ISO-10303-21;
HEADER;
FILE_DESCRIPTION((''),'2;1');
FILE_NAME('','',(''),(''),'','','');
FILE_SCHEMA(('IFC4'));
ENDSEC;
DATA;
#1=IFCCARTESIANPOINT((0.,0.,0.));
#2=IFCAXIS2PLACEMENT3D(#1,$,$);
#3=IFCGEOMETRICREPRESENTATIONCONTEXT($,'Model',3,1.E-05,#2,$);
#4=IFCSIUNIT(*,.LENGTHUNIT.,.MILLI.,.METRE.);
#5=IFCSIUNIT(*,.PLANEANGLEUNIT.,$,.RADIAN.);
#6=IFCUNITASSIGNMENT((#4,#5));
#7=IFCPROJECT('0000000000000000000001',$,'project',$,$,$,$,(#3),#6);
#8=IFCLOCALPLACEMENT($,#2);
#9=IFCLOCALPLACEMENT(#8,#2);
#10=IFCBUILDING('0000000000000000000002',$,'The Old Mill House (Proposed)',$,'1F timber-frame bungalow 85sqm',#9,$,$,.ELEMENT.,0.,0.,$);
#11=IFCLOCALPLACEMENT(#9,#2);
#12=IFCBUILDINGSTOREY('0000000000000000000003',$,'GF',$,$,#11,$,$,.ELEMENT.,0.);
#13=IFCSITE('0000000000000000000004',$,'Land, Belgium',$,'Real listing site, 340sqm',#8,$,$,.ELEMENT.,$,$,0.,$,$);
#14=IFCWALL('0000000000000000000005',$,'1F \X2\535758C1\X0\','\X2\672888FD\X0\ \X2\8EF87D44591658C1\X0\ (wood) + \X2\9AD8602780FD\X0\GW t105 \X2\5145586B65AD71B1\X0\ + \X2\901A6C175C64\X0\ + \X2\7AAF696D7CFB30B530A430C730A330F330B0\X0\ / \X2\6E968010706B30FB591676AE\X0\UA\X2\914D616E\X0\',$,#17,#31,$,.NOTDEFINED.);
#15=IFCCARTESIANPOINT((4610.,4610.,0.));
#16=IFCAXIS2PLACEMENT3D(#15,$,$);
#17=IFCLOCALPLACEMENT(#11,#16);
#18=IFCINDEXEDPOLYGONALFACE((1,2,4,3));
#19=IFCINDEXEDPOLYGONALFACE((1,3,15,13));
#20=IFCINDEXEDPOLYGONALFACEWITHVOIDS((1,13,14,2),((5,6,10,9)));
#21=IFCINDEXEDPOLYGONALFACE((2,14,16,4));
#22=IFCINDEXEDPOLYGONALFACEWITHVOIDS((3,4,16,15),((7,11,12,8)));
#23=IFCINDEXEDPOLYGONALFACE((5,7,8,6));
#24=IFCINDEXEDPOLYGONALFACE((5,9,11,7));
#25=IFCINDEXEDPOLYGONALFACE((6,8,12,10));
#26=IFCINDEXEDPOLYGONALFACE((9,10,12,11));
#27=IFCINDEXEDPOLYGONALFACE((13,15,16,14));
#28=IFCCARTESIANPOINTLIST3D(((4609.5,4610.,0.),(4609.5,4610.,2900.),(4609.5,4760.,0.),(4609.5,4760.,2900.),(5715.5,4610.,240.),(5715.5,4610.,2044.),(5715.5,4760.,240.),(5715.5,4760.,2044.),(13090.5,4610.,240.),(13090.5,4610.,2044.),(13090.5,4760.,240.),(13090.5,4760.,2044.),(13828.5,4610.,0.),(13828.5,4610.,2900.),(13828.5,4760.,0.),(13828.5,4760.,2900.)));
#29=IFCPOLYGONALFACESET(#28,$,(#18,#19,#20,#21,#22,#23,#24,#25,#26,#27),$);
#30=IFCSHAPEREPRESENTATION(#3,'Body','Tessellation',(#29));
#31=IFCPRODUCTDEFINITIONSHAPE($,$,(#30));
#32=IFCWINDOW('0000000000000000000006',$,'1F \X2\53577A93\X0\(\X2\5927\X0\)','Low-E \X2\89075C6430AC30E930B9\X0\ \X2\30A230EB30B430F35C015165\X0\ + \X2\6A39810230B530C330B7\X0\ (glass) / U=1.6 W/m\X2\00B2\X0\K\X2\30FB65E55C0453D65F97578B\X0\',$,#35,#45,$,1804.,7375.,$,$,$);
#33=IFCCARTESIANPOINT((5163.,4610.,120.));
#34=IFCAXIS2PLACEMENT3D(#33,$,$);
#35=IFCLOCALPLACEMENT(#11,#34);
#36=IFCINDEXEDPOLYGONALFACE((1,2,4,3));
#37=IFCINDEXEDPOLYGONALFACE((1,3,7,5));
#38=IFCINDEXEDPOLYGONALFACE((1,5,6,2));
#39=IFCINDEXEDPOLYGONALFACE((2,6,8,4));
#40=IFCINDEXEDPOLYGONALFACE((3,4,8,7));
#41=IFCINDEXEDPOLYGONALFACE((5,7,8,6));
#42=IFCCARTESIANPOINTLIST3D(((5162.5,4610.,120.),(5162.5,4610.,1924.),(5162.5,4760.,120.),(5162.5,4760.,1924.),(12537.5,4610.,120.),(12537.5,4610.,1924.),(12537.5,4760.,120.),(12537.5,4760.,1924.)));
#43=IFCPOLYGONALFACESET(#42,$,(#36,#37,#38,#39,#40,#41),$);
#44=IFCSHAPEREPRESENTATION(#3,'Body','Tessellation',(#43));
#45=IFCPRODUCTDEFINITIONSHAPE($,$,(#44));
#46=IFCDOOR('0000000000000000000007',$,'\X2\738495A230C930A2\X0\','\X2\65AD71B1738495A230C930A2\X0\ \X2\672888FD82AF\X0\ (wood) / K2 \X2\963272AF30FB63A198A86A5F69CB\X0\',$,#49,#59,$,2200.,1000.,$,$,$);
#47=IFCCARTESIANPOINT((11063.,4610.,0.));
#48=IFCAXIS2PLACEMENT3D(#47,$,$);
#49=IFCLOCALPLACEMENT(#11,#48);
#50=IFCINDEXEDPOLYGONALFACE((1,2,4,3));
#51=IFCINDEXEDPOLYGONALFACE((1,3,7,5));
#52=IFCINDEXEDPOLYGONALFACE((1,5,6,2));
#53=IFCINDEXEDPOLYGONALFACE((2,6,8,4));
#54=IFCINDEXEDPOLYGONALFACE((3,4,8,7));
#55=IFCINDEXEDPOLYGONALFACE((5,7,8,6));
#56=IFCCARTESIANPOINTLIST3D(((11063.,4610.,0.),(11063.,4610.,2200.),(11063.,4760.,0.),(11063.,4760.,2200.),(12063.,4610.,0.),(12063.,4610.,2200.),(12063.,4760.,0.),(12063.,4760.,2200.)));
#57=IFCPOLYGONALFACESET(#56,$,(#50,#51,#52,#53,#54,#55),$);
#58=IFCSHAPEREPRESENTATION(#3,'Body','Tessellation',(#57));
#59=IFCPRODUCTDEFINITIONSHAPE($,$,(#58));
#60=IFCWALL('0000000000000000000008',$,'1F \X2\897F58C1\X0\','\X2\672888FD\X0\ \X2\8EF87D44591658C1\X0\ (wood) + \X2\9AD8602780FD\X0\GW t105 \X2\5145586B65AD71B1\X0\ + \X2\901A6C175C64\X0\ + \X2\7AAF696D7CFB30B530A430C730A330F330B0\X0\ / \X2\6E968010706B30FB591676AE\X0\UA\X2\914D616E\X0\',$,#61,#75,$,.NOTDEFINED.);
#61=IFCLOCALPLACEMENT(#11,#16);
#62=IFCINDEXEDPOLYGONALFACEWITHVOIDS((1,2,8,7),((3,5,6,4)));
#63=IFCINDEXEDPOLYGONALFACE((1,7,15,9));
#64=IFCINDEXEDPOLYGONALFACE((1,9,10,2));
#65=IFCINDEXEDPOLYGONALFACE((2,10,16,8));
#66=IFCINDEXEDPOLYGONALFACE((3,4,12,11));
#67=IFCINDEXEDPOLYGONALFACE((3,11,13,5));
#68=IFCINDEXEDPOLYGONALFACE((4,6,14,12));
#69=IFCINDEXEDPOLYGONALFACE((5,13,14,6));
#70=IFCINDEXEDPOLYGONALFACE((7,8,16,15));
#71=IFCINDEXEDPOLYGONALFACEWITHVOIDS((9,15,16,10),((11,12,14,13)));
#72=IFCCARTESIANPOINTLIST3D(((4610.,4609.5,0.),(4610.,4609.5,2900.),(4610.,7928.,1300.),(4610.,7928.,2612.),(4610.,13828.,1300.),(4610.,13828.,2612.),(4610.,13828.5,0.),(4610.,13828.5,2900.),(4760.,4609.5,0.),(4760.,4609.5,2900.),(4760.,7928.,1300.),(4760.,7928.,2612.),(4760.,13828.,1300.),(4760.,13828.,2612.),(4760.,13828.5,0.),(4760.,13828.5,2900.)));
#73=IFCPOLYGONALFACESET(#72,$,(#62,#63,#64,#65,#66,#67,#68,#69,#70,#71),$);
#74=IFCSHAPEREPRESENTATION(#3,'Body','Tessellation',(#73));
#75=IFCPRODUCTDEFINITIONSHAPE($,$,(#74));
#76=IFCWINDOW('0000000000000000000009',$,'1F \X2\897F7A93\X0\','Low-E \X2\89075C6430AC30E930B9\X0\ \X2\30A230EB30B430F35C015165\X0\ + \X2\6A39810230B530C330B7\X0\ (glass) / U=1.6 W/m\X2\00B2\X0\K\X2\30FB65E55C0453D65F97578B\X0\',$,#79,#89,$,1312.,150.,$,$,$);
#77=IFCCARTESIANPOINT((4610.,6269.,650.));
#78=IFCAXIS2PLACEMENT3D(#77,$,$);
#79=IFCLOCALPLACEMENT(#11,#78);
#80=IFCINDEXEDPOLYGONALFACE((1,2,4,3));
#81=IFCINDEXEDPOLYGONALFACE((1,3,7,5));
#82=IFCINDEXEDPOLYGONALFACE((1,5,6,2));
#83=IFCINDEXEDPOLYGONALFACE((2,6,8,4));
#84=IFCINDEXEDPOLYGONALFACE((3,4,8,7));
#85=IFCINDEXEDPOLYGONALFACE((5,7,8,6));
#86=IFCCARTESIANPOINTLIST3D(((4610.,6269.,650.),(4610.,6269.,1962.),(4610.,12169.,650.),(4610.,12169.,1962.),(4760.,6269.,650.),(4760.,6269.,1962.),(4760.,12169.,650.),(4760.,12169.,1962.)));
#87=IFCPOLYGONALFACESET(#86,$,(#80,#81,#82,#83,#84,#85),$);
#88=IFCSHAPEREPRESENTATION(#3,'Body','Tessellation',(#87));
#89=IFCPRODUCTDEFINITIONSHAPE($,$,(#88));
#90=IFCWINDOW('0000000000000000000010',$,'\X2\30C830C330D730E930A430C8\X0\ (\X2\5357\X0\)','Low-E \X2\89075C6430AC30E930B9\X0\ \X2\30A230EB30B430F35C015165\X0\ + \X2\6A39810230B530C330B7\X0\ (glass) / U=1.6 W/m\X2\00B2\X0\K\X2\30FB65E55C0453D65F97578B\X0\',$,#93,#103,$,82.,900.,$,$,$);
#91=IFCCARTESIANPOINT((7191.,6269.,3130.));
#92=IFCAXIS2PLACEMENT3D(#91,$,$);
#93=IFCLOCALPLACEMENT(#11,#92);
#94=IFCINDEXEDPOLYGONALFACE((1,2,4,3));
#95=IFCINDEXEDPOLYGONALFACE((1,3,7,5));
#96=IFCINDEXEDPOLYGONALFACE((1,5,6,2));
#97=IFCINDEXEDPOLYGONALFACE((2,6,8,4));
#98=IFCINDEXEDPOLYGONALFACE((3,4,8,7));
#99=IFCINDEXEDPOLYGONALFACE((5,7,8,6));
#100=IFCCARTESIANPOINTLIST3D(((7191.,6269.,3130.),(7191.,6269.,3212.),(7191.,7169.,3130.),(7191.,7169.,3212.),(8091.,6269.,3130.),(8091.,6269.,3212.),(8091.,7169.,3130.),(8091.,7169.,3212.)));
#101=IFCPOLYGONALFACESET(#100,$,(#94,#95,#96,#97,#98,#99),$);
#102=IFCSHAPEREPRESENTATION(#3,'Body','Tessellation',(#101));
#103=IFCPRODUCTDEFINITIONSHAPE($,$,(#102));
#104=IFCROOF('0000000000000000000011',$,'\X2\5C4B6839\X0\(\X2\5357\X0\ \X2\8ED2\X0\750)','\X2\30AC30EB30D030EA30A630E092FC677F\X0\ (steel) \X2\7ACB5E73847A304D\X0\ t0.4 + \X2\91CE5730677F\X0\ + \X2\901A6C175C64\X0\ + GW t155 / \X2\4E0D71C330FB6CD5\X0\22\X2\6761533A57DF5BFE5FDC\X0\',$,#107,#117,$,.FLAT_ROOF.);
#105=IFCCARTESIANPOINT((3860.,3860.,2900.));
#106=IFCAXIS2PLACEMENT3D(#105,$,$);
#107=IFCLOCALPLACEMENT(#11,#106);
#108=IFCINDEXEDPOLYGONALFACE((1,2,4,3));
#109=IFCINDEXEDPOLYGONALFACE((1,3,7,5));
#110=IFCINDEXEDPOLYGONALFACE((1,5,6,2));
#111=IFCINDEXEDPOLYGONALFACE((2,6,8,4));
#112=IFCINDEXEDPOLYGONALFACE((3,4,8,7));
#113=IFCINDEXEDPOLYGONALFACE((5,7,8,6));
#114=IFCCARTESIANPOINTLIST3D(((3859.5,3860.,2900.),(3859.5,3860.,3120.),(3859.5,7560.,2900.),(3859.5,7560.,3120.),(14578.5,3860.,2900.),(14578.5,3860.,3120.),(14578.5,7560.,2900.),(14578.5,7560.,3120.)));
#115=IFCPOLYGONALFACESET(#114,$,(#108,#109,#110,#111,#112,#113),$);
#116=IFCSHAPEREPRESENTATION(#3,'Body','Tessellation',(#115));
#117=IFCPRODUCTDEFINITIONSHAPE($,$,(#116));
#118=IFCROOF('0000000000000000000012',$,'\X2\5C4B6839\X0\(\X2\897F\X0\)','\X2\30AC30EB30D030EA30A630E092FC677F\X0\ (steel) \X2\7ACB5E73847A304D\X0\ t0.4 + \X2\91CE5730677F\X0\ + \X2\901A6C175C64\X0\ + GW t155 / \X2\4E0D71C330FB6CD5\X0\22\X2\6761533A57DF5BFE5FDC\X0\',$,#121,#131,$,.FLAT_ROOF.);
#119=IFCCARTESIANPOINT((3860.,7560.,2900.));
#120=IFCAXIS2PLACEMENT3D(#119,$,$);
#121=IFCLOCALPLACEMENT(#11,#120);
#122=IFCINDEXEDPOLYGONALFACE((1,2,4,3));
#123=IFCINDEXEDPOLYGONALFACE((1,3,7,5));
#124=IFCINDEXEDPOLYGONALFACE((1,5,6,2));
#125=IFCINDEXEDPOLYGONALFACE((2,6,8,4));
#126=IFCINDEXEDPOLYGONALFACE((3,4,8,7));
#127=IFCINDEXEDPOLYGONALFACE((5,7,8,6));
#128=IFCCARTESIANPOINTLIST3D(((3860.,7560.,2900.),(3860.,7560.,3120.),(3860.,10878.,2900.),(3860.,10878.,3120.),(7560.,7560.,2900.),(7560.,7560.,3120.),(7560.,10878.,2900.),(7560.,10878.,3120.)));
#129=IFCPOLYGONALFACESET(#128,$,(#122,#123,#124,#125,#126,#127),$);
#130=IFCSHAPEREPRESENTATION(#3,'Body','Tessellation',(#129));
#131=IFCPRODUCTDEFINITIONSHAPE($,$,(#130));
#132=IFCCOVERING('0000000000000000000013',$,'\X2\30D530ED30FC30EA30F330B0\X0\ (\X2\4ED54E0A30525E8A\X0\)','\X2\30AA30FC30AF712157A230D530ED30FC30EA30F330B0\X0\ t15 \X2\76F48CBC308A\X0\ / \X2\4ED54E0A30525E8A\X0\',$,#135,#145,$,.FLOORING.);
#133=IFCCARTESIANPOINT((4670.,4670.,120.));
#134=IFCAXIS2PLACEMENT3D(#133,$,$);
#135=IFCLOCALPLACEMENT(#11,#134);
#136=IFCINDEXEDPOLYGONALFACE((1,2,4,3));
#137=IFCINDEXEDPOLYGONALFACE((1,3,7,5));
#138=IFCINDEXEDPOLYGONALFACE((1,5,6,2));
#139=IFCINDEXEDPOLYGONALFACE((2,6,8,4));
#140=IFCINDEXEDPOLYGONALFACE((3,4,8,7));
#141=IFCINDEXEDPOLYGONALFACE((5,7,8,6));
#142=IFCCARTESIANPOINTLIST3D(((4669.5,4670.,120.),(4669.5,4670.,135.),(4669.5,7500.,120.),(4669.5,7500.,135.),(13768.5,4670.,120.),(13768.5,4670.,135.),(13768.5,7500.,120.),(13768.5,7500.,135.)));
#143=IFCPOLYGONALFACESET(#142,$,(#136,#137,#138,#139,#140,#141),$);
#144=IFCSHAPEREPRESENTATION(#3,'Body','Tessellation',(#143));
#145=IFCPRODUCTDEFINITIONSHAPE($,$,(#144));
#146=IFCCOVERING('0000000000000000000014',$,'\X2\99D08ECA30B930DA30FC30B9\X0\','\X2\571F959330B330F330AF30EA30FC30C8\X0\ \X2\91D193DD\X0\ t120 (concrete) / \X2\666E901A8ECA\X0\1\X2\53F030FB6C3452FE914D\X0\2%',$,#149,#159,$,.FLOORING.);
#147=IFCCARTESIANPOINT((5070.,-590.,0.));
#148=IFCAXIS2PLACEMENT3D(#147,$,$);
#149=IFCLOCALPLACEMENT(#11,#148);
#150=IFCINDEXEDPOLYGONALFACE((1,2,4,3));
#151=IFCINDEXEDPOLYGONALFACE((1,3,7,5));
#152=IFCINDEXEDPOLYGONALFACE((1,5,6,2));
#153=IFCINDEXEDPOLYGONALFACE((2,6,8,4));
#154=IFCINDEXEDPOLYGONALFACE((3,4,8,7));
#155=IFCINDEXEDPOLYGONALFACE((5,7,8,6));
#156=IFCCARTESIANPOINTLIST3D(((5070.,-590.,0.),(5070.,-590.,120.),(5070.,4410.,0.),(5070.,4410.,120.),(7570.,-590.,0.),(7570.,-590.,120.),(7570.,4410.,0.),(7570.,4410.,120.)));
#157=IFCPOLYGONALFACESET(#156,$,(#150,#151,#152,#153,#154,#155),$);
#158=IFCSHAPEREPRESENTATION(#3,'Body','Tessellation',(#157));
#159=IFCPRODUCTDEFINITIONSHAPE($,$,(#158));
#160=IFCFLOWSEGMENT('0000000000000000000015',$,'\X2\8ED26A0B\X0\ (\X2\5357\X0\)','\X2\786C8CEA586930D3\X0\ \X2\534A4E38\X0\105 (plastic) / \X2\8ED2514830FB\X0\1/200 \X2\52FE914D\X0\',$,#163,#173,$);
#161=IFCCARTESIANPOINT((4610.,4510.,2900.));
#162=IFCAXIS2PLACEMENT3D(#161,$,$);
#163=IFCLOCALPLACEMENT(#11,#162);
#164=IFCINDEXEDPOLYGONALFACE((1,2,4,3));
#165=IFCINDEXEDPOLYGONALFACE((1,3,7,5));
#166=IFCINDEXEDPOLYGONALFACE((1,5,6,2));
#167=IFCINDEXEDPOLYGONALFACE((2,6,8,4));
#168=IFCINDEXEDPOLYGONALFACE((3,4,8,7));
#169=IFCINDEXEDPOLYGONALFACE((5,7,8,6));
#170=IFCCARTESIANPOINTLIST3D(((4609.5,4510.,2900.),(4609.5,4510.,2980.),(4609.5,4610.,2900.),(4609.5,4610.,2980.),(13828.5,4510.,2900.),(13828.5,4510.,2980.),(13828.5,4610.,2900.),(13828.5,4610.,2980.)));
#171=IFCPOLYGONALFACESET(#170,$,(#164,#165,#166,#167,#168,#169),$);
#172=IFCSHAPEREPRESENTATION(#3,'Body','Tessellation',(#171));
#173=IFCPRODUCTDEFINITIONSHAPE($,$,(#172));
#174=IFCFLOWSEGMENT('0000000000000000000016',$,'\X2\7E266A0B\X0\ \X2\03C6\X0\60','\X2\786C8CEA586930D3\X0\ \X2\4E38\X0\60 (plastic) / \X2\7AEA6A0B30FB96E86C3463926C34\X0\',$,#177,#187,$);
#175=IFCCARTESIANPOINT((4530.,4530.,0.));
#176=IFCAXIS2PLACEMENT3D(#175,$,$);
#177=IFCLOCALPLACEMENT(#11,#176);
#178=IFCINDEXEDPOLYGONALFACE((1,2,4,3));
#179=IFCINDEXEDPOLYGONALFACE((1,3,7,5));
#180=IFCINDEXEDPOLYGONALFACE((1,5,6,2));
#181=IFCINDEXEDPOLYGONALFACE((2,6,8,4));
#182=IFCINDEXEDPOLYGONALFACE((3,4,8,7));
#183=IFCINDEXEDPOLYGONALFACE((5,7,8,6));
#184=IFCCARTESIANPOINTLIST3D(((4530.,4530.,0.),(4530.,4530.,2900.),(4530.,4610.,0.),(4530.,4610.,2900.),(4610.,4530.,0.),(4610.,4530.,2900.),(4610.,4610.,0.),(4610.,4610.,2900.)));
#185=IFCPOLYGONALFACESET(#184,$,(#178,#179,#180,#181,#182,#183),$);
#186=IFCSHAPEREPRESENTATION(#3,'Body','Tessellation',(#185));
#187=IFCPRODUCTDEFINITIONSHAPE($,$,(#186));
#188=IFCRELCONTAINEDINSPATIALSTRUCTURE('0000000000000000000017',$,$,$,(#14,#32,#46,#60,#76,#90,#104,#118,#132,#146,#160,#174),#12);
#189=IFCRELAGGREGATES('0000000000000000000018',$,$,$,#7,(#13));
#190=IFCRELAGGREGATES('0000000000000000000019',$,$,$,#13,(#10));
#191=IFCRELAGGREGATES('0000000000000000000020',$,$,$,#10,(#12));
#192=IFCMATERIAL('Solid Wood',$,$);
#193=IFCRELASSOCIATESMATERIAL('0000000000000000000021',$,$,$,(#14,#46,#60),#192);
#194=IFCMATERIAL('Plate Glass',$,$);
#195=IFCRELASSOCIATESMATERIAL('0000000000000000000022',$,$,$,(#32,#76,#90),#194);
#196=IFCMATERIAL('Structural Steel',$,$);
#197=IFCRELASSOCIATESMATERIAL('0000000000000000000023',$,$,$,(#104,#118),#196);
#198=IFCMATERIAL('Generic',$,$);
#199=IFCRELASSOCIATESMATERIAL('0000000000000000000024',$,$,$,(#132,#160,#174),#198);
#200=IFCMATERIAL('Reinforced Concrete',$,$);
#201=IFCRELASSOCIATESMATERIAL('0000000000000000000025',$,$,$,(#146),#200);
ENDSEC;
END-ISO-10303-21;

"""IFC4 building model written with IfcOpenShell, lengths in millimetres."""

from ifc_helpers import new_model, si_unit, frame, frame_2d, origin, place, context, project, spatial, rectangle, extrude, material, element, fill, save


model = new_model("IFC4")

# Units and contexts
model_context = context("Model", 3, precision=1e-05, world=origin())
ifc_project = project(units=[si_unit("LENGTHUNIT", "METRE", prefix="MILLI"), si_unit("PLANEANGLEUNIT", "RADIAN")], contexts=[model_context])

# Site, building, storey
site_placement = place(None, origin())
site = spatial("IfcSite", under=ifc_project, at=site_placement, Name="Land, Belgium", ObjectType="Real listing site, 340sqm", CompositionType="ELEMENT", RefElevation=0.0)
building_placement = place(site_placement, origin())
building = spatial("IfcBuilding", under=site, at=building_placement, Name="The Old Mill House (Proposed)", ObjectType="1F timber-frame bungalow 85sqm", CompositionType="ELEMENT", ElevationOfRefHeight=0.0, ElevationOfTerrain=0.0)
storey_placement = place(building_placement, origin())
storey = spatial("IfcBuildingStorey", under=building, at=storey_placement, Name="GF", CompositionType="ELEMENT", Elevation=0.0)

# Shared definitions
ifc_material_1 = material(Name="Solid Wood")

# Shared definitions
ifc_material_2 = material(Name="Reinforced Concrete")

# Wall, openings, window, door
wall_1_placement = place(storey_placement, frame((4610.0, 4610.0, 0.0)))
wall_1 = element("IfcWall", 1, at=wall_1_placement, inside=storey, material=ifc_material_1, Name="1F 南壁", Description="木製 軸組外壁 (wood) + 高性能GW t105 充填断熱 + 通気層 + 窯業系サイディング / 準耐火・外皮UA配慮", PredefinedType="NOTDEFINED", context=model_context, shape_type="SweptSolid", body=[
    extrude(rectangle(XDim=9219.0, YDim=150.0, at=frame_2d((4609.0, 75.0))), frame((4610.0, 4610.0, 0.0)), (0.0, 0.0, 1.0), 2900.0),
])
opening_1_placement = place(storey_placement, frame((5163.0, 4610.0, 120.0)))
opening_1 = element("IfcOpeningElement", 2, at=opening_1_placement, cuts=wall_1, PredefinedType="NOTDEFINED", context=model_context, shape_type="SweptSolid", body=[
    extrude(rectangle(XDim=7375.0, YDim=150.0, at=frame_2d((3687.0, 75.0))), frame((5163.0, 4610.0, 120.0)), (0.0, 0.0, 1.0), 1804.0),
])
opening_2_placement = place(storey_placement, frame((11063.0, 4610.0, 0.0)))
opening_2 = element("IfcOpeningElement", 3, at=opening_2_placement, cuts=wall_1, PredefinedType="NOTDEFINED", context=model_context, shape_type="SweptSolid", body=[
    extrude(rectangle(XDim=1000.0, YDim=150.0, at=frame_2d((500.0, 75.0))), frame((11063.0, 4610.0, 0.0)), (0.0, 0.0, 1.0), 2200.0),
])
ifc_material_3 = material(Name="Plate Glass")
window_1_placement = place(storey_placement, frame((5163.0, 4610.0, 120.0)))
window_1 = element("IfcWindow", 4, at=window_1_placement, inside=storey, material=ifc_material_3, Name="1F 南窓(大)", Description="Low-E 複層ガラス アルゴン封入 + 樹脂サッシ (glass) / U=1.6 W/m²K・日射取得型", OverallHeight=1804.0, OverallWidth=7375.0, context=model_context, shape_type="SweptSolid", body=[
    extrude(rectangle(XDim=7375.0, YDim=150.0, at=frame_2d((3687.0, 75.0))), frame((5163.0, 4610.0, 120.0)), (0.0, 0.0, 1.0), 1804.0),
])
fill(opening_1, window_1)
door_placement = place(storey_placement, frame((11063.0, 4610.0, 0.0)))
door = element("IfcDoor", 5, at=door_placement, inside=storey, material=ifc_material_1, Name="玄関ドア", Description="断熱玄関ドア 木製芯 (wood) / K2 防犯・採風機構", OverallHeight=2200.0, OverallWidth=1000.0, context=model_context, shape_type="SweptSolid", body=[
    extrude(rectangle(XDim=1000.0, YDim=150.0, at=frame_2d((500.0, 75.0))), frame((11063.0, 4610.0, 0.0)), (0.0, 0.0, 1.0), 2200.0),
])
fill(opening_2, door)

# Wall, opening, window
wall_2_placement = place(storey_placement, frame((4610.0, 4610.0, 0.0)))
wall_2 = element("IfcWall", 6, at=wall_2_placement, inside=storey, material=ifc_material_1, Name="1F 西壁", Description="木製 軸組外壁 (wood) + 高性能GW t105 充填断熱 + 通気層 + 窯業系サイディング / 準耐火・外皮UA配慮", PredefinedType="NOTDEFINED", context=model_context, shape_type="SweptSolid", body=[
    extrude(rectangle(XDim=150.0, YDim=9219.0, at=frame_2d((75.0, 4609.0))), frame((4610.0, 4610.0, 0.0)), (0.0, 0.0, 1.0), 2900.0),
])
opening_3_placement = place(storey_placement, frame((4610.0, 6269.0, 650.0)))
opening_3 = element("IfcOpeningElement", 7, at=opening_3_placement, cuts=wall_2, PredefinedType="NOTDEFINED", context=model_context, shape_type="SweptSolid", body=[
    extrude(rectangle(XDim=150.0, YDim=5900.0, at=frame_2d((75.0, 2950.0))), frame((4610.0, 6269.0, 650.0)), (0.0, 0.0, 1.0), 1312.0),
])
window_2_placement = place(storey_placement, frame((4610.0, 6269.0, 650.0)))
window_2 = element("IfcWindow", 8, at=window_2_placement, inside=storey, material=ifc_material_3, Name="1F 西窓", Description="Low-E 複層ガラス アルゴン封入 + 樹脂サッシ (glass) / U=1.6 W/m²K・日射取得型", OverallHeight=1312.0, OverallWidth=150.0, context=model_context, shape_type="SweptSolid", body=[
    extrude(rectangle(XDim=150.0, YDim=5900.0, at=frame_2d((75.0, 2950.0))), frame((4610.0, 6269.0, 650.0)), (0.0, 0.0, 1.0), 1312.0),
])
fill(opening_3, window_2)

# Window
window_3_placement = place(storey_placement, frame((7191.0, 6269.0, 3130.0)))
element("IfcWindow", 9, at=window_3_placement, inside=storey, material=ifc_material_3, Name="トップライト (南)", Description="Low-E 複層ガラス アルゴン封入 + 樹脂サッシ (glass) / U=1.6 W/m²K・日射取得型", OverallHeight=82.0, OverallWidth=900.0, context=model_context, shape_type="SweptSolid", body=[
    extrude(rectangle(XDim=900.0, YDim=900.0, at=frame_2d((450.0, 450.0))), frame((7191.0, 6269.0, 3130.0)), (0.0, 0.0, 1.0), 82.0),
])

# Roofs
ifc_material_4 = material(Name="Structural Steel")
roof_1_placement = place(storey_placement, frame((3860.0, 3860.0, 2900.0)))
element("IfcRoof", 10, at=roof_1_placement, inside=storey, material=ifc_material_4, Name="屋根(南 軒750)", Description="ガルバリウム鋼板 (steel) 立平葺き t0.4 + 野地板 + 通気層 + GW t155 / 不燃・法22条区域対応", PredefinedType="FLAT_ROOF", context=model_context, shape_type="SweptSolid", body=[
    extrude(rectangle(XDim=10719.0, YDim=3700.0, at=frame_2d((5359.0, 1850.0))), frame((3860.0, 3860.0, 2900.0)), (0.0, 0.0, 1.0), 220.0),
])
roof_2_placement = place(storey_placement, frame((3860.0, 7560.0, 2900.0)))
element("IfcRoof", 11, at=roof_2_placement, inside=storey, material=ifc_material_4, Name="屋根(西)", Description="ガルバリウム鋼板 (steel) 立平葺き t0.4 + 野地板 + 通気層 + GW t155 / 不燃・法22条区域対応", PredefinedType="FLAT_ROOF", context=model_context, shape_type="SweptSolid", body=[
    extrude(rectangle(XDim=3700.0, YDim=3318.0, at=frame_2d((1850.0, 1659.0))), frame((3860.0, 7560.0, 2900.0)), (0.0, 0.0, 1.0), 220.0),
])

# Coverings
ifc_material_5 = material(Name="Generic")
covering_1_placement = place(storey_placement, frame((4670.0, 4670.0, 120.0)))
element("IfcCovering", 12, at=covering_1_placement, inside=storey, material=ifc_material_5, Name="フローリング (仕上げ床)", Description="オーク無垢フローリング t15 直貼り / 仕上げ床", PredefinedType="FLOORING", context=model_context, shape_type="SweptSolid", body=[
    extrude(rectangle(XDim=9099.0, YDim=2830.0, at=frame_2d((4549.0, 1415.0))), frame((4670.0, 4670.0, 120.0)), (0.0, 0.0, 1.0), 15.0),
])
covering_2_placement = place(storey_placement, frame((5070.0, -590.0, 0.0)))
element("IfcCovering", 13, at=covering_2_placement, inside=storey, material=ifc_material_2, Name="駐車スペース", Description="土間コンクリート 金鏝 t120 (concrete) / 普通車1台・水勾配2%", PredefinedType="FLOORING", context=model_context, shape_type="SweptSolid", body=[
    extrude(rectangle(XDim=2500.0, YDim=5000.0, at=frame_2d((1250.0, 2500.0))), frame((5070.0, -590.0, 0.0)), (0.0, 0.0, 1.0), 120.0),
])

# Flow segments
flow_segment_1_placement = place(storey_placement, frame((4610.0, 4510.0, 2900.0)))
element("IfcFlowSegment", 14, at=flow_segment_1_placement, inside=storey, material=ifc_material_5, Name="軒樋 (南)", Description="硬質塩ビ 半丸105 (plastic) / 軒先・1/200 勾配", context=model_context, shape_type="SweptSolid", body=[
    extrude(rectangle(XDim=9219.0, YDim=100.0, at=frame_2d((4609.0, 50.0))), frame((4610.0, 4510.0, 2900.0)), (0.0, 0.0, 1.0), 80.0),
])
flow_segment_2_placement = place(storey_placement, frame((4530.0, 4530.0, 0.0)))
element("IfcFlowSegment", 15, at=flow_segment_2_placement, inside=storey, material=ifc_material_5, Name="縦樋 φ60", Description="硬質塩ビ 丸60 (plastic) / 竪樋・雨水排水", context=model_context, shape_type="SweptSolid", body=[
    extrude(rectangle(XDim=80.0, YDim=80.0, at=frame_2d((40.0, 40.0))), frame((4530.0, 4530.0, 0.0)), (0.0, 0.0, 1.0), 2900.0),
])

save(model, "model.ifc")
